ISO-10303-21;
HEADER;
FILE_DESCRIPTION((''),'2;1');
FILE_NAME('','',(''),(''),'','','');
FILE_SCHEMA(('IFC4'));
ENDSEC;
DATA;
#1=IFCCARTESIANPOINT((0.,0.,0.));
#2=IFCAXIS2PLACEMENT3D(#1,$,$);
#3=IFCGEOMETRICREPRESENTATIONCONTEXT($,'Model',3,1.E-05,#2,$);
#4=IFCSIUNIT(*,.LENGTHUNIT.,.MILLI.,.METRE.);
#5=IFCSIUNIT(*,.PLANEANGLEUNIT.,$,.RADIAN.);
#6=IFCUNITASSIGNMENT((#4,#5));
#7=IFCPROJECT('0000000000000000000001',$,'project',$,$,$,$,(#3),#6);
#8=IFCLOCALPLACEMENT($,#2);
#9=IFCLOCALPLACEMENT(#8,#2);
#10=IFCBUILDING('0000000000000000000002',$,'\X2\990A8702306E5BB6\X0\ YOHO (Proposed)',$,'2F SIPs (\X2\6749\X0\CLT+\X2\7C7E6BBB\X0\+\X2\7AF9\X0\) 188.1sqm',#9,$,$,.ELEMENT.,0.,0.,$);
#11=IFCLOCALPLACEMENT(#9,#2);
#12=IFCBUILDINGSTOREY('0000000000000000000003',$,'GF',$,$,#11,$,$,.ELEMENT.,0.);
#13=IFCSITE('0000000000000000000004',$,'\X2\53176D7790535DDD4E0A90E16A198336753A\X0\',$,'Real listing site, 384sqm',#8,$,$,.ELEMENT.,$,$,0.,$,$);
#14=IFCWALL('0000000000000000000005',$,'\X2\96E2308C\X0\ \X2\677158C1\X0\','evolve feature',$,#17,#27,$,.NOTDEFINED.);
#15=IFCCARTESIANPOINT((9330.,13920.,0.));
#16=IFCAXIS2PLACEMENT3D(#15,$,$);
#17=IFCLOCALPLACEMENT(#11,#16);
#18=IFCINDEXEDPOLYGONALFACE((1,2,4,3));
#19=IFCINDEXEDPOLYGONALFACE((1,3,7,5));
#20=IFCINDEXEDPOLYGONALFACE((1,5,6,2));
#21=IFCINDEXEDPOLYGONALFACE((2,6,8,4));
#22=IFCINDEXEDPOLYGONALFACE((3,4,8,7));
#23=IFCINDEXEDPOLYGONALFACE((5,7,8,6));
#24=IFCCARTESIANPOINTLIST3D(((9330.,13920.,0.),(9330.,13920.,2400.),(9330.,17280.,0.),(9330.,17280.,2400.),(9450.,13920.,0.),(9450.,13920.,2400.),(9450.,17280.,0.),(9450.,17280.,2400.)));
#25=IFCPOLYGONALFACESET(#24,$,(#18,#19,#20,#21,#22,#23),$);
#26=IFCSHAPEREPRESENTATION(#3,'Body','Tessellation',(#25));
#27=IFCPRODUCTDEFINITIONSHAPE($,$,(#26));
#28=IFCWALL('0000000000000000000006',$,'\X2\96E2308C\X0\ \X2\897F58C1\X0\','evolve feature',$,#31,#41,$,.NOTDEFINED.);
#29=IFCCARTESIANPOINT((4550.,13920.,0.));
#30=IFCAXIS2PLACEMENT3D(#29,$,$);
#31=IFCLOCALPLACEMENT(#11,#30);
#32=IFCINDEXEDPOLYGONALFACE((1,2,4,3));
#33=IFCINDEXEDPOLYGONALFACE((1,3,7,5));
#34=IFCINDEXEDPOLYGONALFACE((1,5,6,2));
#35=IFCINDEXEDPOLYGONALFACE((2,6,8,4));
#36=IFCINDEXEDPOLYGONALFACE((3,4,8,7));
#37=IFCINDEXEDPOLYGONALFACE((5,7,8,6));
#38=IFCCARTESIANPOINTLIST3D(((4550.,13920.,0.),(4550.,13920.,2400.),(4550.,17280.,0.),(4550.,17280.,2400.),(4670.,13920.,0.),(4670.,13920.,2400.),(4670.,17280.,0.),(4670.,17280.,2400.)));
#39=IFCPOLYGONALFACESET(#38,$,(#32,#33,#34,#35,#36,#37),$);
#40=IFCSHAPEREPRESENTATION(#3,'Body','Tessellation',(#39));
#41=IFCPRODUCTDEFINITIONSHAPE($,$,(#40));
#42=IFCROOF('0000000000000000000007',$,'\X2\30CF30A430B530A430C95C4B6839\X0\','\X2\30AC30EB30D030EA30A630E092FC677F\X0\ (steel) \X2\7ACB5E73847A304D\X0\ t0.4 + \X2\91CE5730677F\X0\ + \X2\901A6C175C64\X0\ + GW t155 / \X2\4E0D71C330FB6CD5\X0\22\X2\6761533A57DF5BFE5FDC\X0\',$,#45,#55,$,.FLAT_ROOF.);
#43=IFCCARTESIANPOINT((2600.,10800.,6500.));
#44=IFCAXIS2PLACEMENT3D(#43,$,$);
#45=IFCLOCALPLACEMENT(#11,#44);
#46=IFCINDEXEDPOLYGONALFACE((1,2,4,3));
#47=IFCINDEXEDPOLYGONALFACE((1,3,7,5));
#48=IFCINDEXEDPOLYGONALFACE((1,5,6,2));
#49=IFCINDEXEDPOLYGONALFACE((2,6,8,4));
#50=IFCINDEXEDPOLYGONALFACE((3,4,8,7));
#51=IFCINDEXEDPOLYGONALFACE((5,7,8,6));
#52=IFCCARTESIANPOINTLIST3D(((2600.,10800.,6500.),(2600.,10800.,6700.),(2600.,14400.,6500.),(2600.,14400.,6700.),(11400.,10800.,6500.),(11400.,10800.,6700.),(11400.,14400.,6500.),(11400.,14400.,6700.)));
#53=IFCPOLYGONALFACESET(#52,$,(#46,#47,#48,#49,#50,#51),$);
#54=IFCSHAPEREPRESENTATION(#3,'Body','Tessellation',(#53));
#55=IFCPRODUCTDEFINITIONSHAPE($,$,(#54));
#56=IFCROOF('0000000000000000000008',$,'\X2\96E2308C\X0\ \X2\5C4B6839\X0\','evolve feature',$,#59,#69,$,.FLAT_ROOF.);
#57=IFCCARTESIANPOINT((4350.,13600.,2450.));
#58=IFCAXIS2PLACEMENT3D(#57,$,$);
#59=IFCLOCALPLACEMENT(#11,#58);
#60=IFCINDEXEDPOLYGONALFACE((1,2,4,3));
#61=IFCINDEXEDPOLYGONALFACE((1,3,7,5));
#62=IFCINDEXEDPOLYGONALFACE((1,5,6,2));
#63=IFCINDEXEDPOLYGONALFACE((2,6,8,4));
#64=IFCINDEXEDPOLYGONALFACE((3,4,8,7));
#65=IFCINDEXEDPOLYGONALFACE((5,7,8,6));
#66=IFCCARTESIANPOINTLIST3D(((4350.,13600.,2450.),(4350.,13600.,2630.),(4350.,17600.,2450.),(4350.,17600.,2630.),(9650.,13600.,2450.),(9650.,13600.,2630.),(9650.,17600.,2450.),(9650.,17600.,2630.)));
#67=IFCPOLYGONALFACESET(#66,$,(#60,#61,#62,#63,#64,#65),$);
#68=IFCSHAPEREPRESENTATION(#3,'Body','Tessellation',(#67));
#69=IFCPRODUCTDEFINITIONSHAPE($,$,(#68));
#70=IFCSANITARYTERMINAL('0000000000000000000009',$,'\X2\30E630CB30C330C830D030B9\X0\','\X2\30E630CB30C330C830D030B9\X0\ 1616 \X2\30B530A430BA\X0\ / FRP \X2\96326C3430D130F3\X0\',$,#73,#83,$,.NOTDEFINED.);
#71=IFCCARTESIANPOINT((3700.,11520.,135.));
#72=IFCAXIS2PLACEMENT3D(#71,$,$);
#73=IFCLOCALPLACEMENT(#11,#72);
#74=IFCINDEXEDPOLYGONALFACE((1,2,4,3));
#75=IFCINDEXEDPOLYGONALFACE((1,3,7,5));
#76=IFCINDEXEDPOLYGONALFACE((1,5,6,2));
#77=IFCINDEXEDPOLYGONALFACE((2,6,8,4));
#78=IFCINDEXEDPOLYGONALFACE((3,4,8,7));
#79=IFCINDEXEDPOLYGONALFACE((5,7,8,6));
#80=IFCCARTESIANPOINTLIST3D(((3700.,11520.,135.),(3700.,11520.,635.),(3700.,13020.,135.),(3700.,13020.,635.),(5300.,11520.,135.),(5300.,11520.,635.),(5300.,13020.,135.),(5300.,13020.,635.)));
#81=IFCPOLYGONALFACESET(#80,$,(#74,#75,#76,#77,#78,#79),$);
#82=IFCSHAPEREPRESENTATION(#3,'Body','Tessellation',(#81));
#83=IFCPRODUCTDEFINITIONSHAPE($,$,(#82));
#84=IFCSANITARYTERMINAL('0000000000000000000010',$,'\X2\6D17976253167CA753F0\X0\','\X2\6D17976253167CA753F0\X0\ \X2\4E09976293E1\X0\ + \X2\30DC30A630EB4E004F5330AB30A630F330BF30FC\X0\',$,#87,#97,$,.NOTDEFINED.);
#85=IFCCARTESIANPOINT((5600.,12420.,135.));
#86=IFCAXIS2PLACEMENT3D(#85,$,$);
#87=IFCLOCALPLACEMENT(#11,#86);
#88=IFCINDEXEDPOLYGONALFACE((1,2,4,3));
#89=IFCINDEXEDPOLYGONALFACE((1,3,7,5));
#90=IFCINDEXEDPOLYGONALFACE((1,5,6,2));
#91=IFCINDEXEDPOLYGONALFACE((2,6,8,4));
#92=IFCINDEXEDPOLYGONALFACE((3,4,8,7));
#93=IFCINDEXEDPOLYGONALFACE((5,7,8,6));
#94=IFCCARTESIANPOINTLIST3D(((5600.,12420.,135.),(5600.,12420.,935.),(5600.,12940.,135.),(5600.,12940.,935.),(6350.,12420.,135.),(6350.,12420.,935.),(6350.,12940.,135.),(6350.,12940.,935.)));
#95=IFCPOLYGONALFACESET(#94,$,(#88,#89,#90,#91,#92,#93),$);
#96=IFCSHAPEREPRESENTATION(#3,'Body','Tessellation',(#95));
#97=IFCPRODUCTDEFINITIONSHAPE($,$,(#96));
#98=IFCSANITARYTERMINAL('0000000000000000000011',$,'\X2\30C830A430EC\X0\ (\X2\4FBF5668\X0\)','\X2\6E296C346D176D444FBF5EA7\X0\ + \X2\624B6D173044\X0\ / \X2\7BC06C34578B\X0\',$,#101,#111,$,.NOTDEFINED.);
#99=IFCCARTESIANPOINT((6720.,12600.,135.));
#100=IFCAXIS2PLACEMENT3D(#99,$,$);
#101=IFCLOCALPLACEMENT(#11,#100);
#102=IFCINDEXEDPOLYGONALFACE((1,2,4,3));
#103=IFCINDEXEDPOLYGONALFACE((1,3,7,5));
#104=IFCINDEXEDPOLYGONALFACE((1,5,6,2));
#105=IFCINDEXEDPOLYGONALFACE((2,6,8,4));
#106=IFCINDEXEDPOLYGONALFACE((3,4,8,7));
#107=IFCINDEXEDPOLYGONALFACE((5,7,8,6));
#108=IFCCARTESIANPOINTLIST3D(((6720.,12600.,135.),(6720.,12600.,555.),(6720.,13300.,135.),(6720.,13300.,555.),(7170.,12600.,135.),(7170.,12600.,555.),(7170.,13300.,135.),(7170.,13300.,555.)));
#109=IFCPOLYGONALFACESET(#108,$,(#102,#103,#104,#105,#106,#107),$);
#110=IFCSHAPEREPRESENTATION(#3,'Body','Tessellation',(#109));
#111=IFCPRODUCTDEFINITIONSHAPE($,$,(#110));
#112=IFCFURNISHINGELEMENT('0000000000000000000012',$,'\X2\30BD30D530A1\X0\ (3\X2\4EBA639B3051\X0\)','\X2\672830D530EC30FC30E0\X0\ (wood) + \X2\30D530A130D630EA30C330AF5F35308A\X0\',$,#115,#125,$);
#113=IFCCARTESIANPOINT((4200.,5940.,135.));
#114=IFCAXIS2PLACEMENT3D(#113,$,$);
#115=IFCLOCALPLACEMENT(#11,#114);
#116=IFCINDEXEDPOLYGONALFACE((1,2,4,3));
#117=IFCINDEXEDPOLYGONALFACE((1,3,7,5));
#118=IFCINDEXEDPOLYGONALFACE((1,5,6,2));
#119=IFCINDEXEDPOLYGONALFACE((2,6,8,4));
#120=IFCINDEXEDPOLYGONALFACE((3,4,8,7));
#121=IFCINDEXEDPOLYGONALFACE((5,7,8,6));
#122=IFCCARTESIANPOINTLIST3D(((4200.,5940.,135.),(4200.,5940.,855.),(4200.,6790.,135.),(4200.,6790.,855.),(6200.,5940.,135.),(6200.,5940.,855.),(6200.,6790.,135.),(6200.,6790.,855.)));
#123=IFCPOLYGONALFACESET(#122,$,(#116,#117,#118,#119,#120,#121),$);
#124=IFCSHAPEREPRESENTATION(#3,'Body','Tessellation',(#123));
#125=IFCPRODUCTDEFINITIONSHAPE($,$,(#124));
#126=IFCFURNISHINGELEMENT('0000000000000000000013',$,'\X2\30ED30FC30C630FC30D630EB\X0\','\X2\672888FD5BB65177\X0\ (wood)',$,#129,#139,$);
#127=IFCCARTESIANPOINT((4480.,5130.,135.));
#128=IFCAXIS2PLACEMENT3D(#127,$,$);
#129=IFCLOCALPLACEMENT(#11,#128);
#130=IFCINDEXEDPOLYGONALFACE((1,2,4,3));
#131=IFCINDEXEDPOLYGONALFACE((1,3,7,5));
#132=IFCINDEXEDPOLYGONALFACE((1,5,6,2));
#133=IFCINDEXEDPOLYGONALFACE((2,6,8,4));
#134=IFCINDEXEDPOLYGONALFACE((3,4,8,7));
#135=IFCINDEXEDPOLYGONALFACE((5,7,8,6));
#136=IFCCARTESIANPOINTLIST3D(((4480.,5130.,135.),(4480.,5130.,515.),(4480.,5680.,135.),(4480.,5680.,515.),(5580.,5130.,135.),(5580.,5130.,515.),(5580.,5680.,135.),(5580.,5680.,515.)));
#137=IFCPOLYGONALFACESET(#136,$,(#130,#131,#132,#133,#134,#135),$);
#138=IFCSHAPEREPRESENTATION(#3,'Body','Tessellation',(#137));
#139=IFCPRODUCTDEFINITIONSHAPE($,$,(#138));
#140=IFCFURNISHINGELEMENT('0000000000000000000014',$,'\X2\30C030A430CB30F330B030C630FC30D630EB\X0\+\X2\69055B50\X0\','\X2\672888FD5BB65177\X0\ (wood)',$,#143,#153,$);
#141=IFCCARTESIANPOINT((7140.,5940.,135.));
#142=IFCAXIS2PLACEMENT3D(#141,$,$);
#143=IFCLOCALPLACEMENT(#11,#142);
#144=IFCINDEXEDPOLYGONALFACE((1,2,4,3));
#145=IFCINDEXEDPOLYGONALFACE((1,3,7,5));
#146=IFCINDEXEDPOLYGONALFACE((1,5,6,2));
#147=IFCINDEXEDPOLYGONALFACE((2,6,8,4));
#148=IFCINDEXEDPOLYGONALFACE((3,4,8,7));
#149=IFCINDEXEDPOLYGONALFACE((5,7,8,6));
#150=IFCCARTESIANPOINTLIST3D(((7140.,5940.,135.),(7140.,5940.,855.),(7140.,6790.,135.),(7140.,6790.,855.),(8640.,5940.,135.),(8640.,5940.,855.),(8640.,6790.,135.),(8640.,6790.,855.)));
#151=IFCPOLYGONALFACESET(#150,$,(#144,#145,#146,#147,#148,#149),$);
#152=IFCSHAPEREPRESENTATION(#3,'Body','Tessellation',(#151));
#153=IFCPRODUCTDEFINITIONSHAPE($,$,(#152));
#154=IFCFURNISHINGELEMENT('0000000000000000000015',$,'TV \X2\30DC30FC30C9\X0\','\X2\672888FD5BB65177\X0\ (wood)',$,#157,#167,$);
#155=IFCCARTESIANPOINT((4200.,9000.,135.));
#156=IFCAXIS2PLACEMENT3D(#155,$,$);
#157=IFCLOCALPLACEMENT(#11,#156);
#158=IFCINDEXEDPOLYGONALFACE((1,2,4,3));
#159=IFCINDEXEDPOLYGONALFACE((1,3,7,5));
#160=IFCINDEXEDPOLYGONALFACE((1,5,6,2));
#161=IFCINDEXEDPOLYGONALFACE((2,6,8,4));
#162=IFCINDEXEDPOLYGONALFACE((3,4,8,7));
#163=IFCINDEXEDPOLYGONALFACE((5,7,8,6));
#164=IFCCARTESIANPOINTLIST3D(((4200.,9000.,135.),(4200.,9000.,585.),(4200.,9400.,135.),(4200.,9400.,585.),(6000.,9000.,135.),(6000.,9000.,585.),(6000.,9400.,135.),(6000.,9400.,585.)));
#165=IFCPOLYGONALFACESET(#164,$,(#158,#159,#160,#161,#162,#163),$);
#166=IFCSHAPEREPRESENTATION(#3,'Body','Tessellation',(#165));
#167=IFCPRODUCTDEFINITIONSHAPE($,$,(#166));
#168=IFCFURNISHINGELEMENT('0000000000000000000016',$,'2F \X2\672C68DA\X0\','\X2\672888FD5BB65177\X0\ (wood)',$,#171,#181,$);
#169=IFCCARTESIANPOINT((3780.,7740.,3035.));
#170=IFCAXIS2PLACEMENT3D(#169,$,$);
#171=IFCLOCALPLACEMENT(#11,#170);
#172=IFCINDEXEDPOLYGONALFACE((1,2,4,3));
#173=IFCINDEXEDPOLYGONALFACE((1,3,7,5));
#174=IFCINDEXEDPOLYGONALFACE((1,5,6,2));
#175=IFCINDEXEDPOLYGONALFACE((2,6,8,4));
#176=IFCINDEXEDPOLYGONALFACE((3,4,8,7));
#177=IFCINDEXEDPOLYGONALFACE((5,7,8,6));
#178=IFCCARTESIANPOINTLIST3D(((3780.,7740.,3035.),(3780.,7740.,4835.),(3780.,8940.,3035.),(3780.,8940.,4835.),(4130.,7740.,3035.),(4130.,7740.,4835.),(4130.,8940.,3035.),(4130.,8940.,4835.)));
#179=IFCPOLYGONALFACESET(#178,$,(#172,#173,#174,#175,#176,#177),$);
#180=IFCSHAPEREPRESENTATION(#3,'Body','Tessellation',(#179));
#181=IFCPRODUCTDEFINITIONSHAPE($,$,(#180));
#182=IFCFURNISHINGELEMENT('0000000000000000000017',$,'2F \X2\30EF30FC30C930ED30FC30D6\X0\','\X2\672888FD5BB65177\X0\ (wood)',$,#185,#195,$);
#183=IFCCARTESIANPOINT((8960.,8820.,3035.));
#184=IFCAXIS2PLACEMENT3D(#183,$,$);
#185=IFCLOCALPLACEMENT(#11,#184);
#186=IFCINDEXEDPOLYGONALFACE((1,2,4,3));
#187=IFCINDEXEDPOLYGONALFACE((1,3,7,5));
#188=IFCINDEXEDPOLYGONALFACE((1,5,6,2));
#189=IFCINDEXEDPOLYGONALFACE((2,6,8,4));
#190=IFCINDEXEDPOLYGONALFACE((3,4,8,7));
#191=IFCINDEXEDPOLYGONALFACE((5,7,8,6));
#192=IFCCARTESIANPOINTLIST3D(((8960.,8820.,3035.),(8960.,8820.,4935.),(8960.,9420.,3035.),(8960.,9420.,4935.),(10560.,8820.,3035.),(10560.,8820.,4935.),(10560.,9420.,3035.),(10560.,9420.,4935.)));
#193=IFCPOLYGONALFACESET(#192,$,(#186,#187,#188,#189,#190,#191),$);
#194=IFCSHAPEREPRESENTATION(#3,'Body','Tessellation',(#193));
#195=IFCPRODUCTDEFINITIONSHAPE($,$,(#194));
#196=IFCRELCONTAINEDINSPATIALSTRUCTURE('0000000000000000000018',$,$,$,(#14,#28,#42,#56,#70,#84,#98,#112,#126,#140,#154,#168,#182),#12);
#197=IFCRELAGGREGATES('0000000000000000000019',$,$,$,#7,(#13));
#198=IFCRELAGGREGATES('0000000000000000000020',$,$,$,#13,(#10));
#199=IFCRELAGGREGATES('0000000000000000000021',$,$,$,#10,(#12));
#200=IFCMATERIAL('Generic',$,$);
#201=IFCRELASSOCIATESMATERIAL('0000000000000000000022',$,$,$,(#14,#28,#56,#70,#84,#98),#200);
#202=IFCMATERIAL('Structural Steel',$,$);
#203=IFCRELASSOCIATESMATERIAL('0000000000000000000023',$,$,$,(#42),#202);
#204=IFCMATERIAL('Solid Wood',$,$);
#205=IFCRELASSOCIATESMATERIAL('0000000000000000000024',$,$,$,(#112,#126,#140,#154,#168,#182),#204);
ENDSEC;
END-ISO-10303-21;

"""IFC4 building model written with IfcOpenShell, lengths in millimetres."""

from ifc_helpers import new_model, si_unit, frame, frame_2d, origin, place, context, project, spatial, rectangle, extrude, material, element, save


model = new_model("IFC4")

# Units and contexts
model_context = context("Model", 3, precision=1e-05, world=origin())
ifc_project = project(units=[si_unit("LENGTHUNIT", "METRE", prefix="MILLI"), si_unit("PLANEANGLEUNIT", "RADIAN")], contexts=[model_context])

# Site, building, storey
site_placement = place(None, origin())
site = spatial("IfcSite", under=ifc_project, at=site_placement, Name="北海道川上郡標茶町", ObjectType="Real listing site, 384sqm", CompositionType="ELEMENT", RefElevation=0.0)
building_placement = place(site_placement, origin())
building = spatial("IfcBuilding", under=site, at=building_placement, Name="養蜂の家 YOHO (Proposed)", ObjectType="2F SIPs (杉CLT+籾殻+竹) 188.1sqm", CompositionType="ELEMENT", ElevationOfRefHeight=0.0, ElevationOfTerrain=0.0)
storey_placement = place(building_placement, origin())
storey = spatial("IfcBuildingStorey", under=building, at=storey_placement, Name="GF", CompositionType="ELEMENT", Elevation=0.0)

# Shared definitions
ifc_material_1 = material(Name="Generic")

# Shared definitions
ifc_material_2 = material(Name="Solid Wood")

# Walls
wall_1_placement = place(storey_placement, frame((9330.0, 13920.0, 0.0)))
element("IfcWall", 1, at=wall_1_placement, inside=storey, material=ifc_material_1, Name="離れ 東壁", Description="evolve feature", PredefinedType="NOTDEFINED", context=model_context, shape_type="SweptSolid", body=[
    extrude(rectangle(XDim=120.0, YDim=3360.0, at=frame_2d((60.0, 1680.0))), frame((9330.0, 13920.0, 0.0)), (0.0, 0.0, 1.0), 2400.0),
])
wall_2_placement = place(storey_placement, frame((4550.0, 13920.0, 0.0)))
element("IfcWall", 2, at=wall_2_placement, inside=storey, material=ifc_material_1, Name="離れ 西壁", Description="evolve feature", PredefinedType="NOTDEFINED", context=model_context, shape_type="SweptSolid", body=[
    extrude(rectangle(XDim=120.0, YDim=3360.0, at=frame_2d((60.0, 1680.0))), frame((4550.0, 13920.0, 0.0)), (0.0, 0.0, 1.0), 2400.0),
])

# Roofs
ifc_material_3 = material(Name="Structural Steel")
roof_1_placement = place(storey_placement, frame((2600.0, 10800.0, 6500.0)))
element("IfcRoof", 3, at=roof_1_placement, inside=storey, material=ifc_material_3, Name="ハイサイド屋根", Description="ガルバリウム鋼板 (steel) 立平葺き t0.4 + 野地板 + 通気層 + GW t155 / 不燃・法22条区域対応", PredefinedType="FLAT_ROOF", context=model_context, shape_type="SweptSolid", body=[
    extrude(rectangle(XDim=8800.0, YDim=3600.0, at=frame_2d((4400.0, 1800.0))), frame((2600.0, 10800.0, 6500.0)), (0.0, 0.0, 1.0), 200.0),
])
roof_2_placement = place(storey_placement, frame((4350.0, 13600.0, 2450.0)))
element("IfcRoof", 4, at=roof_2_placement, inside=storey, material=ifc_material_1, Name="離れ 屋根", Description="evolve feature", PredefinedType="FLAT_ROOF", context=model_context, shape_type="SweptSolid", body=[
    extrude(rectangle(XDim=5300.0, YDim=4000.0, at=frame_2d((2650.0, 2000.0))), frame((4350.0, 13600.0, 2450.0)), (0.0, 0.0, 1.0), 180.0),
])

# Sanitary terminals
sanitary_terminal_1_placement = place(storey_placement, frame((3700.0, 11520.0, 135.0)))
element("IfcSanitaryTerminal", 5, at=sanitary_terminal_1_placement, inside=storey, material=ifc_material_1, Name="ユニットバス", Description="ユニットバス 1616 サイズ / FRP 防水パン", PredefinedType="NOTDEFINED", context=model_context, shape_type="SweptSolid", body=[
    extrude(rectangle(XDim=1600.0, YDim=1500.0, at=frame_2d((800.0, 750.0))), frame((3700.0, 11520.0, 135.0)), (0.0, 0.0, 1.0), 500.0),
])
sanitary_terminal_2_placement = place(storey_placement, frame((5600.0, 12420.0, 135.0)))
element("IfcSanitaryTerminal", 6, at=sanitary_terminal_2_placement, inside=storey, material=ifc_material_1, Name="洗面化粧台", Description="洗面化粧台 三面鏡 + ボウル一体カウンター", PredefinedType="NOTDEFINED", context=model_context, shape_type="SweptSolid", body=[
    extrude(rectangle(XDim=750.0, YDim=520.0, at=frame_2d((375.0, 260.0))), frame((5600.0, 12420.0, 135.0)), (0.0, 0.0, 1.0), 800.0),
])
sanitary_terminal_3_placement = place(storey_placement, frame((6720.0, 12600.0, 135.0)))
element("IfcSanitaryTerminal", 7, at=sanitary_terminal_3_placement, inside=storey, material=ifc_material_1, Name="トイレ (便器)", Description="温水洗浄便座 + 手洗い / 節水型", PredefinedType="NOTDEFINED", context=model_context, shape_type="SweptSolid", body=[
    extrude(rectangle(XDim=450.0, YDim=700.0, at=frame_2d((225.0, 350.0))), frame((6720.0, 12600.0, 135.0)), (0.0, 0.0, 1.0), 420.0),
])

# Furnishing elements
furnishing_1_placement = place(storey_placement, frame((4200.0, 5940.0, 135.0)))
element("IfcFurnishingElement", 8, at=furnishing_1_placement, inside=storey, material=ifc_material_2, Name="ソファ (3人掛け)", Description="木フレーム (wood) + ファブリック張り", context=model_context, shape_type="SweptSolid", body=[
    extrude(rectangle(XDim=2000.0, YDim=850.0, at=frame_2d((1000.0, 425.0))), frame((4200.0, 5940.0, 135.0)), (0.0, 0.0, 1.0), 720.0),
])
furnishing_2_placement = place(storey_placement, frame((4480.0, 5130.0, 135.0)))
element("IfcFurnishingElement", 9, at=furnishing_2_placement, inside=storey, material=ifc_material_2, Name="ローテーブル", Description="木製家具 (wood)", context=model_context, shape_type="SweptSolid", body=[
    extrude(rectangle(XDim=1100.0, YDim=550.0, at=frame_2d((550.0, 275.0))), frame((4480.0, 5130.0, 135.0)), (0.0, 0.0, 1.0), 380.0),
])
furnishing_3_placement = place(storey_placement, frame((7140.0, 5940.0, 135.0)))
element("IfcFurnishingElement", 10, at=furnishing_3_placement, inside=storey, material=ifc_material_2, Name="ダイニングテーブル+椅子", Description="木製家具 (wood)", context=model_context, shape_type="SweptSolid", body=[
    extrude(rectangle(XDim=1500.0, YDim=850.0, at=frame_2d((750.0, 425.0))), frame((7140.0, 5940.0, 135.0)), (0.0, 0.0, 1.0), 720.0),
])
furnishing_4_placement = place(storey_placement, frame((4200.0, 9000.0, 135.0)))
element("IfcFurnishingElement", 11, at=furnishing_4_placement, inside=storey, material=ifc_material_2, Name="TV ボード", Description="木製家具 (wood)", context=model_context, shape_type="SweptSolid", body=[
    extrude(rectangle(XDim=1800.0, YDim=400.0, at=frame_2d((900.0, 200.0))), frame((4200.0, 9000.0, 135.0)), (0.0, 0.0, 1.0), 450.0),
])
furnishing_5_placement = place(storey_placement, frame((3780.0, 7740.0, 3035.0)))
element("IfcFurnishingElement", 12, at=furnishing_5_placement, inside=storey, material=ifc_material_2, Name="2F 本棚", Description="木製家具 (wood)", context=model_context, shape_type="SweptSolid", body=[
    extrude(rectangle(XDim=350.0, YDim=1200.0, at=frame_2d((175.0, 600.0))), frame((3780.0, 7740.0, 3035.0)), (0.0, 0.0, 1.0), 1800.0),
])
furnishing_6_placement = place(storey_placement, frame((8960.0, 8820.0, 3035.0)))
element("IfcFurnishingElement", 13, at=furnishing_6_placement, inside=storey, material=ifc_material_2, Name="2F ワードローブ", Description="木製家具 (wood)", context=model_context, shape_type="SweptSolid", body=[
    extrude(rectangle(XDim=1600.0, YDim=600.0, at=frame_2d((800.0, 300.0))), frame((8960.0, 8820.0, 3035.0)), (0.0, 0.0, 1.0), 1900.0),
])

save(model, "model.ifc")
